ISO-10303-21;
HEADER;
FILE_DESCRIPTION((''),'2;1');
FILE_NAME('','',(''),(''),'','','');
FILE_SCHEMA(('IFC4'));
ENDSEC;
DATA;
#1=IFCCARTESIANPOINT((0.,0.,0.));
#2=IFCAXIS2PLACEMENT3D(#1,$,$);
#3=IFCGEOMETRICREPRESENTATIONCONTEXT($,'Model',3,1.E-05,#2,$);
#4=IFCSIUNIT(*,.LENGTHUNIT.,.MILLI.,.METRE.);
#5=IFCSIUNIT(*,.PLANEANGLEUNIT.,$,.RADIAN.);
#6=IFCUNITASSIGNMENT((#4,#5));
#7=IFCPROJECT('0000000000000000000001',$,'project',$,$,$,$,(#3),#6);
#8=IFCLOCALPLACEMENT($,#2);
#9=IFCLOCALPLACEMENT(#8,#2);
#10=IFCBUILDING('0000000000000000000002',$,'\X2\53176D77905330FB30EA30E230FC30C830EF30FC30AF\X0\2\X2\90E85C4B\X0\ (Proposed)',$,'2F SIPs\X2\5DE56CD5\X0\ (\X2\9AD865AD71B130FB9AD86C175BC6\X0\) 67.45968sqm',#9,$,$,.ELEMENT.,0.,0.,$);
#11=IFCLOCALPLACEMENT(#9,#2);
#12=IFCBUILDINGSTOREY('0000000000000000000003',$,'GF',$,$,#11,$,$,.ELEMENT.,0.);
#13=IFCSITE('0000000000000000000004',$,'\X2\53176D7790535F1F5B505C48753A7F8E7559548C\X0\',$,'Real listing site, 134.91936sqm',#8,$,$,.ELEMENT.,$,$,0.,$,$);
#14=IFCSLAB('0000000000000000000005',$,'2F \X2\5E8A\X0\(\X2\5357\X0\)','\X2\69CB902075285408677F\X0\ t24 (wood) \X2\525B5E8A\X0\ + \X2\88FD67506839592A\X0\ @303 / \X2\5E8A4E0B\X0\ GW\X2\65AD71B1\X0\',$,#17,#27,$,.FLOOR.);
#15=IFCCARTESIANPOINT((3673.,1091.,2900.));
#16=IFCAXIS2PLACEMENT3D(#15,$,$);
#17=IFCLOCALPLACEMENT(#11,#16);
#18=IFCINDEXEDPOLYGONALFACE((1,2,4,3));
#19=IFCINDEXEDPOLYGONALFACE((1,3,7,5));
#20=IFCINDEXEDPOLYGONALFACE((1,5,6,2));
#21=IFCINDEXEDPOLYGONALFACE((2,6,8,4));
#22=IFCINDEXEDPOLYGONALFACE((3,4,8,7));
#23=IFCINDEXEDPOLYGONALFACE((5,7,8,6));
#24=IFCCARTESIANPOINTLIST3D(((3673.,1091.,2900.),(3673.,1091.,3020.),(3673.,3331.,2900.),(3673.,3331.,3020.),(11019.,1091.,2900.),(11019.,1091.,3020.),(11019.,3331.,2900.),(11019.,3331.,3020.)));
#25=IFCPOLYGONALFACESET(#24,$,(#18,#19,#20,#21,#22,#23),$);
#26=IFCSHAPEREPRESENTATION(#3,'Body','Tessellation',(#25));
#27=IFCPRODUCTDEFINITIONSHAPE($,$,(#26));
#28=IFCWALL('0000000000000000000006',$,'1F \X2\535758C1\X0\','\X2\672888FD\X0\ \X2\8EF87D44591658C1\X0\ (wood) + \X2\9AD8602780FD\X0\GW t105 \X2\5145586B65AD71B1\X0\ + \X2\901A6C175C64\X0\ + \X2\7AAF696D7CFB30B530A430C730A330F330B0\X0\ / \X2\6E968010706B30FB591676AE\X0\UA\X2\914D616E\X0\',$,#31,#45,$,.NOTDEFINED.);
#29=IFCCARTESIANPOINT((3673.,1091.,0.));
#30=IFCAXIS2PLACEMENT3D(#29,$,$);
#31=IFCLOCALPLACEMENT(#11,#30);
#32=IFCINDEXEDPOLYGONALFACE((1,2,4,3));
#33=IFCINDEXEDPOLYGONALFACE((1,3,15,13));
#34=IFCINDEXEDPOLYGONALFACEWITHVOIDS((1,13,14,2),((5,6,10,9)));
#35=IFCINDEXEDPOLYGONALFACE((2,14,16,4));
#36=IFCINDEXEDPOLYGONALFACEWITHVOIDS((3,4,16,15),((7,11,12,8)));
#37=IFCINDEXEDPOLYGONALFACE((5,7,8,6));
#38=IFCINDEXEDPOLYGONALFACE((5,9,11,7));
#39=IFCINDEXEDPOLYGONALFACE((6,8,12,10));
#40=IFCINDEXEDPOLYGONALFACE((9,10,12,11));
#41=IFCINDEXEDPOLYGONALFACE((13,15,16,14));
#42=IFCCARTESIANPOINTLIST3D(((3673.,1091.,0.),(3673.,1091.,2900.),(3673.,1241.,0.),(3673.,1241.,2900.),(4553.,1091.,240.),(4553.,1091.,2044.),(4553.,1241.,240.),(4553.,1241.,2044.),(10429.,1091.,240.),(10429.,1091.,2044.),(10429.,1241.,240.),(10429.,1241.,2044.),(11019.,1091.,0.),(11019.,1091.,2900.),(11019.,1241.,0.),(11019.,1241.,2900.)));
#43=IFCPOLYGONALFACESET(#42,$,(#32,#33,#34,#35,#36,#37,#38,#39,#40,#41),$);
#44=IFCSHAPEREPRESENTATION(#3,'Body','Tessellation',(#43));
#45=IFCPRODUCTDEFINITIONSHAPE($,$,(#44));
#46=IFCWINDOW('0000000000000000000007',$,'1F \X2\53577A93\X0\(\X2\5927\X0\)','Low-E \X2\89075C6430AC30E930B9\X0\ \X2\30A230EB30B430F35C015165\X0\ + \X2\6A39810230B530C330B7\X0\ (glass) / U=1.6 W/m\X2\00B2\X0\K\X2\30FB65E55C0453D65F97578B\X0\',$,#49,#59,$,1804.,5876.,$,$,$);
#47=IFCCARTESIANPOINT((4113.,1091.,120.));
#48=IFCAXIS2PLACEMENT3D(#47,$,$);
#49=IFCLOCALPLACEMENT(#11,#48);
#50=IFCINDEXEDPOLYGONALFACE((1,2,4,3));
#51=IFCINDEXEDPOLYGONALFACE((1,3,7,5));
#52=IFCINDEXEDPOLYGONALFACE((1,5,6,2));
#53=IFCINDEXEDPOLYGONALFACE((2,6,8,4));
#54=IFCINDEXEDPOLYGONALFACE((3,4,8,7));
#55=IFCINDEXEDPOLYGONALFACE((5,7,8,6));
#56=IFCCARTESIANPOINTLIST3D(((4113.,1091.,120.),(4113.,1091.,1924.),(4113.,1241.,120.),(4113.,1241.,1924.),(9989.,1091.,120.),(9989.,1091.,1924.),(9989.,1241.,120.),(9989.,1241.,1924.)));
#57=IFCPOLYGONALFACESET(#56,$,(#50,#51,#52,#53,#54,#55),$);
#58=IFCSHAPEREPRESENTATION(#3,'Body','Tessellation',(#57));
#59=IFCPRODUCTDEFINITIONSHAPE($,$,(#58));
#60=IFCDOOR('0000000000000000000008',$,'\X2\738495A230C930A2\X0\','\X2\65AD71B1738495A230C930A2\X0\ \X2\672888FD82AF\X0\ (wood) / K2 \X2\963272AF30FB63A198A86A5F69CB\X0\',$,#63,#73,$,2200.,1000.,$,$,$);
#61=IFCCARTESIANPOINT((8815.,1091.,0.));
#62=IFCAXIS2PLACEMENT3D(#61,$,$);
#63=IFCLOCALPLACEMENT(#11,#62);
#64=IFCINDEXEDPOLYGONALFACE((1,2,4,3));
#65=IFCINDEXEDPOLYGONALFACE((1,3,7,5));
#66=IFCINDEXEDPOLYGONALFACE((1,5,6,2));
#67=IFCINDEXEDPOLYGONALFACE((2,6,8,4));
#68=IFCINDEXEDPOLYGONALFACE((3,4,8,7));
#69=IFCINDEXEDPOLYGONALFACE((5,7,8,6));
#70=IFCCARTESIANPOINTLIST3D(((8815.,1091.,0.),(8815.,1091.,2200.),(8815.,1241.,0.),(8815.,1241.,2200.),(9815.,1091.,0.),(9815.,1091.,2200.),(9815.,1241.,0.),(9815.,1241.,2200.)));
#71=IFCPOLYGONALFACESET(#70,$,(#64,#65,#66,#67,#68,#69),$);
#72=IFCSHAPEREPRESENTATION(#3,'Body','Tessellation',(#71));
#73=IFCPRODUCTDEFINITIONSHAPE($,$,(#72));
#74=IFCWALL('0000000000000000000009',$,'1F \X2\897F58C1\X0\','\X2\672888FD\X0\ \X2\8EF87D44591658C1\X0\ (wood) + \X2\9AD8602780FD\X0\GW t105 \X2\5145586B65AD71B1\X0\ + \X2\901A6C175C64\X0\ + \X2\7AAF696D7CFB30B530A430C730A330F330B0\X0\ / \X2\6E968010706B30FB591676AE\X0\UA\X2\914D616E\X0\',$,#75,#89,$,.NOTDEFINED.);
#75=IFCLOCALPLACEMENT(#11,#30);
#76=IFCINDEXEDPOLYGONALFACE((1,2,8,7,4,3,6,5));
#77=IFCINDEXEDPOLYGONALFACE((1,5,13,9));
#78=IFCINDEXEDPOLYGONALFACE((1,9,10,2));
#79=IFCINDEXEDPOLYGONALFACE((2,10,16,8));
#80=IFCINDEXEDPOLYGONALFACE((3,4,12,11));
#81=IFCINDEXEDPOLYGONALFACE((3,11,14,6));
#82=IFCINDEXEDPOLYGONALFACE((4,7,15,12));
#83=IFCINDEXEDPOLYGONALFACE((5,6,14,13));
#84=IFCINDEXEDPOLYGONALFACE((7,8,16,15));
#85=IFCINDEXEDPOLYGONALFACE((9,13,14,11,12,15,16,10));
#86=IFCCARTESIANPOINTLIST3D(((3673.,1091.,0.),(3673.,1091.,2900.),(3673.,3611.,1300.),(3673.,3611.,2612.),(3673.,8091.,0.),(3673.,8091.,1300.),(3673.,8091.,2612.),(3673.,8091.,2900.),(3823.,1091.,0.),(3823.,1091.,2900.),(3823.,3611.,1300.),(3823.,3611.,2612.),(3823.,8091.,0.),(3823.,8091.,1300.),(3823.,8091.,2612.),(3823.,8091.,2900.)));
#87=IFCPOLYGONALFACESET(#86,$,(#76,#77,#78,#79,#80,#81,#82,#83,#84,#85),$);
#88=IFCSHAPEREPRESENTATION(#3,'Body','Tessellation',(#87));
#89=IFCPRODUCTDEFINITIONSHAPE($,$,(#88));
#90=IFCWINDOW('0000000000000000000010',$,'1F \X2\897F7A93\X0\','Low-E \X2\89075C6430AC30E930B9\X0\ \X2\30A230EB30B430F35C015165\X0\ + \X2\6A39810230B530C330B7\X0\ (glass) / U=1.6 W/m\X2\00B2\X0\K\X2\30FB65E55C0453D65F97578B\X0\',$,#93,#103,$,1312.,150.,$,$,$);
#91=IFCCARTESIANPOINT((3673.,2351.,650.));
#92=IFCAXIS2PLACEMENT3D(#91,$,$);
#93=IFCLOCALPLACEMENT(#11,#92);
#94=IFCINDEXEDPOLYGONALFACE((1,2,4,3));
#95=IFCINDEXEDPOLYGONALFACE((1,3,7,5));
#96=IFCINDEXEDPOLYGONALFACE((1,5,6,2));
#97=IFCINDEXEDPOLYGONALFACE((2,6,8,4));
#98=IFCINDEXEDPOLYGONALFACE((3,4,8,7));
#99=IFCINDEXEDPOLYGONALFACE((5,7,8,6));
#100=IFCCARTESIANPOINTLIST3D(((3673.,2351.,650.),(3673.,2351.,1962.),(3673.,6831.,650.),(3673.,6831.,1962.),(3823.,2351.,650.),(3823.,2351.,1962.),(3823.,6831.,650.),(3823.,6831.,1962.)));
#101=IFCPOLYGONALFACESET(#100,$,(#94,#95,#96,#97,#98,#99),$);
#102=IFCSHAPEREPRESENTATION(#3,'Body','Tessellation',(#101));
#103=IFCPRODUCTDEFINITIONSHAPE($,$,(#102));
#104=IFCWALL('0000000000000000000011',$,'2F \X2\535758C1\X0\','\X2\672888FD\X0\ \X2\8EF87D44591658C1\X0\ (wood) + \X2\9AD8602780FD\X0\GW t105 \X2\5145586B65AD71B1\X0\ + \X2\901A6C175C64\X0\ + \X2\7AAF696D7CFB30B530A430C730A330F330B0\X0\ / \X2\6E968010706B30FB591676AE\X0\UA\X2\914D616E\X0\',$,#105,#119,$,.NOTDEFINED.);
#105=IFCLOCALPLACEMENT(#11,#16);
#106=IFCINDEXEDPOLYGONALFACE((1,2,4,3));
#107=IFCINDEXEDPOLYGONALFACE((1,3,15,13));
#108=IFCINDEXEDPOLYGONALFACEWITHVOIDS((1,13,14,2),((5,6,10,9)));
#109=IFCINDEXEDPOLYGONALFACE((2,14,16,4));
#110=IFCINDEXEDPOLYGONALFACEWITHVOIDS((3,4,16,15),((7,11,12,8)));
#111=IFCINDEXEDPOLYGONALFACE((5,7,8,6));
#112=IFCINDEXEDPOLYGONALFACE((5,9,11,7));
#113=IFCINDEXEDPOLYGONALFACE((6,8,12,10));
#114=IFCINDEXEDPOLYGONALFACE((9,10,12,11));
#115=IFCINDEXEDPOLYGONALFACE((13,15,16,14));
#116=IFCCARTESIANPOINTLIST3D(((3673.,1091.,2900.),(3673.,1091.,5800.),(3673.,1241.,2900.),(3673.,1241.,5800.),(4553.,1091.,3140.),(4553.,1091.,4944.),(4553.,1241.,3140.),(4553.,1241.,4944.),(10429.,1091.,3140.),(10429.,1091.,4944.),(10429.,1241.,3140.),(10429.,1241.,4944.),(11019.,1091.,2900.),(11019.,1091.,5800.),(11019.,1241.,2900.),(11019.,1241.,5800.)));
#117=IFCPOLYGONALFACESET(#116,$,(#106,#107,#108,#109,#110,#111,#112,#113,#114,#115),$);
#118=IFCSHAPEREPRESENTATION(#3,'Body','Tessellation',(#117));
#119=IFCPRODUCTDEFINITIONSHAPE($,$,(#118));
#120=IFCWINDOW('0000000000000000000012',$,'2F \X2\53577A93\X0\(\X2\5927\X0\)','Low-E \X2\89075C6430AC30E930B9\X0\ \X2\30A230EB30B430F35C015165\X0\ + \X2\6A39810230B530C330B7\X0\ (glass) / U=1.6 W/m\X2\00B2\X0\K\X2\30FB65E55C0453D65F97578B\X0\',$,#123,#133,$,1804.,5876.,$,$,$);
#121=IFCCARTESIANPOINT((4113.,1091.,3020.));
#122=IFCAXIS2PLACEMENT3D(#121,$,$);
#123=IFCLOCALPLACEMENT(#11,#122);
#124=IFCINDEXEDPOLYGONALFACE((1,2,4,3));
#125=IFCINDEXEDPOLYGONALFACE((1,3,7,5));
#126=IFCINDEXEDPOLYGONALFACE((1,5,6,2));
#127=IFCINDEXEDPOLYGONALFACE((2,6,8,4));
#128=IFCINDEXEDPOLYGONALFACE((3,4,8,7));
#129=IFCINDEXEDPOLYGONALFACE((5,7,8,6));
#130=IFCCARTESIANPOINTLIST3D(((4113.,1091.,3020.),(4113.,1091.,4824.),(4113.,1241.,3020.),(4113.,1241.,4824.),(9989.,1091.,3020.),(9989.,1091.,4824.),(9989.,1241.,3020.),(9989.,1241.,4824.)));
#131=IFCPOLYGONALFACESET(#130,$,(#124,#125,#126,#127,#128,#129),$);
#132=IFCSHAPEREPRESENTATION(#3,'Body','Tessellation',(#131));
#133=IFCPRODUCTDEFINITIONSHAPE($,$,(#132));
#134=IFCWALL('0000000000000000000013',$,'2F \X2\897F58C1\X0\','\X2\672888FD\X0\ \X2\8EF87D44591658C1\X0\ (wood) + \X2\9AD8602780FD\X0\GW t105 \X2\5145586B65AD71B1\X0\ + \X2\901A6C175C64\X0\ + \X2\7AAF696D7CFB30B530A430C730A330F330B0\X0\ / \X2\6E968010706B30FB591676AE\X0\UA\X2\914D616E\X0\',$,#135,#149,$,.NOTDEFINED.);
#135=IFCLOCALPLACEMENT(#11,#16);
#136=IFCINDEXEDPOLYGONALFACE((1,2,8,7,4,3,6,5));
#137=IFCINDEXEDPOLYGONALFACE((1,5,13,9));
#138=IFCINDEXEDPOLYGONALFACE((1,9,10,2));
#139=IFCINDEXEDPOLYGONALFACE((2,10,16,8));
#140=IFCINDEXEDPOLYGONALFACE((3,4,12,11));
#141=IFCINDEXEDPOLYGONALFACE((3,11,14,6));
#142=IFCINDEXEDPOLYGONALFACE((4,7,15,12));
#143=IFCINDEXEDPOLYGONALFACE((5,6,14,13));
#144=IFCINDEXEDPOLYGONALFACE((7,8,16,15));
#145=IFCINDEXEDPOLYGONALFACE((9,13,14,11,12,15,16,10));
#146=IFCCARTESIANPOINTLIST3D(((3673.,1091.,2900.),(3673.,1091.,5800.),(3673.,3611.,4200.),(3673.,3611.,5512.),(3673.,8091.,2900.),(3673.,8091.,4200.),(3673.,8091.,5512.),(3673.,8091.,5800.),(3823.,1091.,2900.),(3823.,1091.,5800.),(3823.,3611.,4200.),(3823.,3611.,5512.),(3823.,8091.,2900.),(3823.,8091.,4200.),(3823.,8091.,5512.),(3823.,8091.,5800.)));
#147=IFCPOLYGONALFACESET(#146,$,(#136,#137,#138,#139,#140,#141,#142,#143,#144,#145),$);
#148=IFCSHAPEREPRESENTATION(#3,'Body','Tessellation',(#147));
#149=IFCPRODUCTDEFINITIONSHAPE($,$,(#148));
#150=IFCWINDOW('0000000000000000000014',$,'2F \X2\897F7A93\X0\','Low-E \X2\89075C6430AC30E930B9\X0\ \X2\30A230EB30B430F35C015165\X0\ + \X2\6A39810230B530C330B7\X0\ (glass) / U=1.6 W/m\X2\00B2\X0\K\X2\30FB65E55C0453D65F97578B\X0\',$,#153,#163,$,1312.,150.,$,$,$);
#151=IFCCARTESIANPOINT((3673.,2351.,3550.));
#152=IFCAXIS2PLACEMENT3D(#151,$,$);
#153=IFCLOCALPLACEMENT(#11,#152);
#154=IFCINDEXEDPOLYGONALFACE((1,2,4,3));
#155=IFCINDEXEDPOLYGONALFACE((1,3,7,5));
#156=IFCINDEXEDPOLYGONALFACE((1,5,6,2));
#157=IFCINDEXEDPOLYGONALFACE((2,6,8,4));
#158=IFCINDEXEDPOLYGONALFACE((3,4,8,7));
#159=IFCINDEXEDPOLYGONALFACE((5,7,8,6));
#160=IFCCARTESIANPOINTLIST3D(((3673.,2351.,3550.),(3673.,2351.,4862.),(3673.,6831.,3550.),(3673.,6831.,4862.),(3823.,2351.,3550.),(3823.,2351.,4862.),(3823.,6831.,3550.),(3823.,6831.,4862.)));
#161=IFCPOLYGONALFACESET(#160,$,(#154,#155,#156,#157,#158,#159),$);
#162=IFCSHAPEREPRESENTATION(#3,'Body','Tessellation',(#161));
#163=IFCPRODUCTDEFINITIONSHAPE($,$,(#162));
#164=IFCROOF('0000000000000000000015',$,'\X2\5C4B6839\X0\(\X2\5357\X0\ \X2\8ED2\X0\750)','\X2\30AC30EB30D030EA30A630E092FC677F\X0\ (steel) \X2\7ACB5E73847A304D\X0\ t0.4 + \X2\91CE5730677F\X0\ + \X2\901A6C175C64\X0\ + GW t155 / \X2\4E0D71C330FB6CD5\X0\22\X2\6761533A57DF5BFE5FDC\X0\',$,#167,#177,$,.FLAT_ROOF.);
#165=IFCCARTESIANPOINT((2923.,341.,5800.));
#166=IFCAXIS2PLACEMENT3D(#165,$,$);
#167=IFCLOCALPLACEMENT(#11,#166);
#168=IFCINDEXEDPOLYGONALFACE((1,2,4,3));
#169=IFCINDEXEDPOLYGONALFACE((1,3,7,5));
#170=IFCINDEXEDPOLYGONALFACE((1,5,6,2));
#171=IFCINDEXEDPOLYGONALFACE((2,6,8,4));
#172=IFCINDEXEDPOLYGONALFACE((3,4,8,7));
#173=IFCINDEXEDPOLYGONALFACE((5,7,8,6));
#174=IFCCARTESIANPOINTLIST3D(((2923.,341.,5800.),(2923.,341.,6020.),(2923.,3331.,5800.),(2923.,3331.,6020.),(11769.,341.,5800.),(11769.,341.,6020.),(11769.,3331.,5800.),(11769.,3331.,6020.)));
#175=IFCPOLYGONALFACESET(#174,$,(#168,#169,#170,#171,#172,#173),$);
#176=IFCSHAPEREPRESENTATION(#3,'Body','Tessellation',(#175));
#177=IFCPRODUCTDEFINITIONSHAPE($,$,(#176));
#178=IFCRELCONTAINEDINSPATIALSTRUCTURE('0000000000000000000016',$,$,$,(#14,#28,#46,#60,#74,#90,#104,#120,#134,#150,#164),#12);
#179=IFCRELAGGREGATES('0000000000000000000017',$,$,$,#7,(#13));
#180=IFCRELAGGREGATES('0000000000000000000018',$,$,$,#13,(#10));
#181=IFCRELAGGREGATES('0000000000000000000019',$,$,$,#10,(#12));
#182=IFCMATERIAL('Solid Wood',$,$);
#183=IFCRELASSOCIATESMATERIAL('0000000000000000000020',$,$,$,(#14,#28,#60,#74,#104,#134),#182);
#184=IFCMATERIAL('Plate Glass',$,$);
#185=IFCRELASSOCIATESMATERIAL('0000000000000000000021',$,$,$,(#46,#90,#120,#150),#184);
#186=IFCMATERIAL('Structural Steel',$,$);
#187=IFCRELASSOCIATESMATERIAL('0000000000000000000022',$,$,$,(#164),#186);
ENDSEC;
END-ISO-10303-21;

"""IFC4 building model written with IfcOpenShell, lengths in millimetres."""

from ifc_helpers import new_model, si_unit, frame, frame_2d, origin, place, context, project, spatial, rectangle, extrude, material, element, fill, save


model = new_model("IFC4")

# Units and contexts
model_context = context("Model", 3, precision=1e-05, world=origin())
ifc_project = project(units=[si_unit("LENGTHUNIT", "METRE", prefix="MILLI"), si_unit("PLANEANGLEUNIT", "RADIAN")], contexts=[model_context])

# Site, building, storey
site_placement = place(None, origin())
site = spatial("IfcSite", under=ifc_project, at=site_placement, Name="北海道弟子屈町美留和", ObjectType="Real listing site, 134.91936sqm", CompositionType="ELEMENT", RefElevation=0.0)
building_placement = place(site_placement, origin())
building = spatial("IfcBuilding", under=site, at=building_placement, Name="北海道・リモートワーク2部屋 (Proposed)", ObjectType="2F SIPs工法 (高断熱・高気密) 67.45968sqm", CompositionType="ELEMENT", ElevationOfRefHeight=0.0, ElevationOfTerrain=0.0)
storey_placement = place(building_placement, origin())
storey = spatial("IfcBuildingStorey", under=building, at=storey_placement, Name="GF", CompositionType="ELEMENT", Elevation=0.0)

# Slab
ifc_material_1 = material(Name="Solid Wood")
slab_1_placement = place(storey_placement, frame((3673.0, 1091.0, 2900.0)))
element("IfcSlab", 1, at=slab_1_placement, inside=storey, material=ifc_material_1, Name="2F 床(南)", Description="構造用合板 t24 (wood) 剛床 + 製材根太 @303 / 床下 GW断熱", PredefinedType="FLOOR", context=model_context, shape_type="SweptSolid", body=[
    extrude(rectangle(XDim=7346.0, YDim=2240.0, at=frame_2d((3673.0, 1120.0))), frame((3673.0, 1091.0, 2900.0)), (0.0, 0.0, 1.0), 120.0),
])

# Wall, openings, window, door
wall_1_placement = place(storey_placement, frame((3673.0, 1091.0, 0.0)))
wall_1 = element("IfcWall", 2, at=wall_1_placement, inside=storey, material=ifc_material_1, Name="1F 南壁", Description="木製 軸組外壁 (wood) + 高性能GW t105 充填断熱 + 通気層 + 窯業系サイディング / 準耐火・外皮UA配慮", PredefinedType="NOTDEFINED", context=model_context, shape_type="SweptSolid", body=[
    extrude(rectangle(XDim=7346.0, YDim=150.0, at=frame_2d((3673.0, 75.0))), frame((3673.0, 1091.0, 0.0)), (0.0, 0.0, 1.0), 2900.0),
])
opening_1_placement = place(storey_placement, frame((4113.0, 1091.0, 120.0)))
opening_1 = element("IfcOpeningElement", 3, at=opening_1_placement, cuts=wall_1, PredefinedType="NOTDEFINED", context=model_context, shape_type="SweptSolid", body=[
    extrude(rectangle(XDim=5876.0, YDim=150.0, at=frame_2d((2938.0, 75.0))), frame((4113.0, 1091.0, 120.0)), (0.0, 0.0, 1.0), 1804.0),
])
opening_2_placement = place(storey_placement, frame((8815.0, 1091.0, 0.0)))
opening_2 = element("IfcOpeningElement", 4, at=opening_2_placement, cuts=wall_1, PredefinedType="NOTDEFINED", context=model_context, shape_type="SweptSolid", body=[
    extrude(rectangle(XDim=1000.0, YDim=150.0, at=frame_2d((500.0, 75.0))), frame((8815.0, 1091.0, 0.0)), (0.0, 0.0, 1.0), 2200.0),
])
ifc_material_2 = material(Name="Plate Glass")
window_1_placement = place(storey_placement, frame((4113.0, 1091.0, 120.0)))
window_1 = element("IfcWindow", 5, at=window_1_placement, inside=storey, material=ifc_material_2, Name="1F 南窓(大)", Description="Low-E 複層ガラス アルゴン封入 + 樹脂サッシ (glass) / U=1.6 W/m²K・日射取得型", OverallHeight=1804.0, OverallWidth=5876.0, context=model_context, shape_type="SweptSolid", body=[
    extrude(rectangle(XDim=5876.0, YDim=150.0, at=frame_2d((2938.0, 75.0))), frame((4113.0, 1091.0, 120.0)), (0.0, 0.0, 1.0), 1804.0),
])
fill(opening_1, window_1)
door_placement = place(storey_placement, frame((8815.0, 1091.0, 0.0)))
door = element("IfcDoor", 6, at=door_placement, inside=storey, material=ifc_material_1, Name="玄関ドア", Description="断熱玄関ドア 木製芯 (wood) / K2 防犯・採風機構", OverallHeight=2200.0, OverallWidth=1000.0, context=model_context, shape_type="SweptSolid", body=[
    extrude(rectangle(XDim=1000.0, YDim=150.0, at=frame_2d((500.0, 75.0))), frame((8815.0, 1091.0, 0.0)), (0.0, 0.0, 1.0), 2200.0),
])
fill(opening_2, door)

# Walls, openings, windows
wall_2_placement = place(storey_placement, frame((3673.0, 1091.0, 0.0)))
wall_2 = element("IfcWall", 7, at=wall_2_placement, inside=storey, material=ifc_material_1, Name="1F 西壁", Description="木製 軸組外壁 (wood) + 高性能GW t105 充填断熱 + 通気層 + 窯業系サイディング / 準耐火・外皮UA配慮", PredefinedType="NOTDEFINED", context=model_context, shape_type="SweptSolid", body=[
    extrude(rectangle(XDim=150.0, YDim=7000.0, at=frame_2d((75.0, 3500.0))), frame((3673.0, 1091.0, 0.0)), (0.0, 0.0, 1.0), 2900.0),
])
opening_3_placement = place(storey_placement, frame((3673.0, 2351.0, 650.0)))
opening_3 = element("IfcOpeningElement", 8, at=opening_3_placement, cuts=wall_2, PredefinedType="NOTDEFINED", context=model_context, shape_type="SweptSolid", body=[
    extrude(rectangle(XDim=150.0, YDim=4480.0, at=frame_2d((75.0, 2240.0))), frame((3673.0, 2351.0, 650.0)), (0.0, 0.0, 1.0), 1312.0),
])
window_2_placement = place(storey_placement, frame((3673.0, 2351.0, 650.0)))
window_2 = element("IfcWindow", 9, at=window_2_placement, inside=storey, material=ifc_material_2, Name="1F 西窓", Description="Low-E 複層ガラス アルゴン封入 + 樹脂サッシ (glass) / U=1.6 W/m²K・日射取得型", OverallHeight=1312.0, OverallWidth=150.0, context=model_context, shape_type="SweptSolid", body=[
    extrude(rectangle(XDim=150.0, YDim=4480.0, at=frame_2d((75.0, 2240.0))), frame((3673.0, 2351.0, 650.0)), (0.0, 0.0, 1.0), 1312.0),
])
fill(opening_3, window_2)
wall_3_placement = place(storey_placement, frame((3673.0, 1091.0, 2900.0)))
wall_3 = element("IfcWall", 10, at=wall_3_placement, inside=storey, material=ifc_material_1, Name="2F 南壁", Description="木製 軸組外壁 (wood) + 高性能GW t105 充填断熱 + 通気層 + 窯業系サイディング / 準耐火・外皮UA配慮", PredefinedType="NOTDEFINED", context=model_context, shape_type="SweptSolid", body=[
    extrude(rectangle(XDim=7346.0, YDim=150.0, at=frame_2d((3673.0, 75.0))), frame((3673.0, 1091.0, 2900.0)), (0.0, 0.0, 1.0), 2900.0),
])
opening_4_placement = place(storey_placement, frame((4113.0, 1091.0, 3020.0)))
opening_4 = element("IfcOpeningElement", 11, at=opening_4_placement, cuts=wall_3, PredefinedType="NOTDEFINED", context=model_context, shape_type="SweptSolid", body=[
    extrude(rectangle(XDim=5876.0, YDim=150.0, at=frame_2d((2938.0, 75.0))), frame((4113.0, 1091.0, 3020.0)), (0.0, 0.0, 1.0), 1804.0),
])
window_3_placement = place(storey_placement, frame((4113.0, 1091.0, 3020.0)))
window_3 = element("IfcWindow", 12, at=window_3_placement, inside=storey, material=ifc_material_2, Name="2F 南窓(大)", Description="Low-E 複層ガラス アルゴン封入 + 樹脂サッシ (glass) / U=1.6 W/m²K・日射取得型", OverallHeight=1804.0, OverallWidth=5876.0, context=model_context, shape_type="SweptSolid", body=[
    extrude(rectangle(XDim=5876.0, YDim=150.0, at=frame_2d((2938.0, 75.0))), frame((4113.0, 1091.0, 3020.0)), (0.0, 0.0, 1.0), 1804.0),
])
fill(opening_4, window_3)
wall_4_placement = place(storey_placement, frame((3673.0, 1091.0, 2900.0)))
wall_4 = element("IfcWall", 13, at=wall_4_placement, inside=storey, material=ifc_material_1, Name="2F 西壁", Description="木製 軸組外壁 (wood) + 高性能GW t105 充填断熱 + 通気層 + 窯業系サイディング / 準耐火・外皮UA配慮", PredefinedType="NOTDEFINED", context=model_context, shape_type="SweptSolid", body=[
    extrude(rectangle(XDim=150.0, YDim=7000.0, at=frame_2d((75.0, 3500.0))), frame((3673.0, 1091.0, 2900.0)), (0.0, 0.0, 1.0), 2900.0),
])
opening_5_placement = place(storey_placement, frame((3673.0, 2351.0, 3550.0)))
opening_5 = element("IfcOpeningElement", 14, at=opening_5_placement, cuts=wall_4, PredefinedType="NOTDEFINED", context=model_context, shape_type="SweptSolid", body=[
    extrude(rectangle(XDim=150.0, YDim=4480.0, at=frame_2d((75.0, 2240.0))), frame((3673.0, 2351.0, 3550.0)), (0.0, 0.0, 1.0), 1312.0),
])
window_4_placement = place(storey_placement, frame((3673.0, 2351.0, 3550.0)))
window_4 = element("IfcWindow", 15, at=window_4_placement, inside=storey, material=ifc_material_2, Name="2F 西窓", Description="Low-E 複層ガラス アルゴン封入 + 樹脂サッシ (glass) / U=1.6 W/m²K・日射取得型", OverallHeight=1312.0, OverallWidth=150.0, context=model_context, shape_type="SweptSolid", body=[
    extrude(rectangle(XDim=150.0, YDim=4480.0, at=frame_2d((75.0, 2240.0))), frame((3673.0, 2351.0, 3550.0)), (0.0, 0.0, 1.0), 1312.0),
])
fill(opening_5, window_4)

# Roof
ifc_material_3 = material(Name="Structural Steel")
roof_1_placement = place(storey_placement, frame((2923.0, 341.0, 5800.0)))
element("IfcRoof", 16, at=roof_1_placement, inside=storey, material=ifc_material_3, Name="屋根(南 軒750)", Description="ガルバリウム鋼板 (steel) 立平葺き t0.4 + 野地板 + 通気層 + GW t155 / 不燃・法22条区域対応", PredefinedType="FLAT_ROOF", context=model_context, shape_type="SweptSolid", body=[
    extrude(rectangle(XDim=8846.0, YDim=2990.0, at=frame_2d((4423.0, 1495.0))), frame((2923.0, 341.0, 5800.0)), (0.0, 0.0, 1.0), 220.0),
])

save(model, "model.ifc")
